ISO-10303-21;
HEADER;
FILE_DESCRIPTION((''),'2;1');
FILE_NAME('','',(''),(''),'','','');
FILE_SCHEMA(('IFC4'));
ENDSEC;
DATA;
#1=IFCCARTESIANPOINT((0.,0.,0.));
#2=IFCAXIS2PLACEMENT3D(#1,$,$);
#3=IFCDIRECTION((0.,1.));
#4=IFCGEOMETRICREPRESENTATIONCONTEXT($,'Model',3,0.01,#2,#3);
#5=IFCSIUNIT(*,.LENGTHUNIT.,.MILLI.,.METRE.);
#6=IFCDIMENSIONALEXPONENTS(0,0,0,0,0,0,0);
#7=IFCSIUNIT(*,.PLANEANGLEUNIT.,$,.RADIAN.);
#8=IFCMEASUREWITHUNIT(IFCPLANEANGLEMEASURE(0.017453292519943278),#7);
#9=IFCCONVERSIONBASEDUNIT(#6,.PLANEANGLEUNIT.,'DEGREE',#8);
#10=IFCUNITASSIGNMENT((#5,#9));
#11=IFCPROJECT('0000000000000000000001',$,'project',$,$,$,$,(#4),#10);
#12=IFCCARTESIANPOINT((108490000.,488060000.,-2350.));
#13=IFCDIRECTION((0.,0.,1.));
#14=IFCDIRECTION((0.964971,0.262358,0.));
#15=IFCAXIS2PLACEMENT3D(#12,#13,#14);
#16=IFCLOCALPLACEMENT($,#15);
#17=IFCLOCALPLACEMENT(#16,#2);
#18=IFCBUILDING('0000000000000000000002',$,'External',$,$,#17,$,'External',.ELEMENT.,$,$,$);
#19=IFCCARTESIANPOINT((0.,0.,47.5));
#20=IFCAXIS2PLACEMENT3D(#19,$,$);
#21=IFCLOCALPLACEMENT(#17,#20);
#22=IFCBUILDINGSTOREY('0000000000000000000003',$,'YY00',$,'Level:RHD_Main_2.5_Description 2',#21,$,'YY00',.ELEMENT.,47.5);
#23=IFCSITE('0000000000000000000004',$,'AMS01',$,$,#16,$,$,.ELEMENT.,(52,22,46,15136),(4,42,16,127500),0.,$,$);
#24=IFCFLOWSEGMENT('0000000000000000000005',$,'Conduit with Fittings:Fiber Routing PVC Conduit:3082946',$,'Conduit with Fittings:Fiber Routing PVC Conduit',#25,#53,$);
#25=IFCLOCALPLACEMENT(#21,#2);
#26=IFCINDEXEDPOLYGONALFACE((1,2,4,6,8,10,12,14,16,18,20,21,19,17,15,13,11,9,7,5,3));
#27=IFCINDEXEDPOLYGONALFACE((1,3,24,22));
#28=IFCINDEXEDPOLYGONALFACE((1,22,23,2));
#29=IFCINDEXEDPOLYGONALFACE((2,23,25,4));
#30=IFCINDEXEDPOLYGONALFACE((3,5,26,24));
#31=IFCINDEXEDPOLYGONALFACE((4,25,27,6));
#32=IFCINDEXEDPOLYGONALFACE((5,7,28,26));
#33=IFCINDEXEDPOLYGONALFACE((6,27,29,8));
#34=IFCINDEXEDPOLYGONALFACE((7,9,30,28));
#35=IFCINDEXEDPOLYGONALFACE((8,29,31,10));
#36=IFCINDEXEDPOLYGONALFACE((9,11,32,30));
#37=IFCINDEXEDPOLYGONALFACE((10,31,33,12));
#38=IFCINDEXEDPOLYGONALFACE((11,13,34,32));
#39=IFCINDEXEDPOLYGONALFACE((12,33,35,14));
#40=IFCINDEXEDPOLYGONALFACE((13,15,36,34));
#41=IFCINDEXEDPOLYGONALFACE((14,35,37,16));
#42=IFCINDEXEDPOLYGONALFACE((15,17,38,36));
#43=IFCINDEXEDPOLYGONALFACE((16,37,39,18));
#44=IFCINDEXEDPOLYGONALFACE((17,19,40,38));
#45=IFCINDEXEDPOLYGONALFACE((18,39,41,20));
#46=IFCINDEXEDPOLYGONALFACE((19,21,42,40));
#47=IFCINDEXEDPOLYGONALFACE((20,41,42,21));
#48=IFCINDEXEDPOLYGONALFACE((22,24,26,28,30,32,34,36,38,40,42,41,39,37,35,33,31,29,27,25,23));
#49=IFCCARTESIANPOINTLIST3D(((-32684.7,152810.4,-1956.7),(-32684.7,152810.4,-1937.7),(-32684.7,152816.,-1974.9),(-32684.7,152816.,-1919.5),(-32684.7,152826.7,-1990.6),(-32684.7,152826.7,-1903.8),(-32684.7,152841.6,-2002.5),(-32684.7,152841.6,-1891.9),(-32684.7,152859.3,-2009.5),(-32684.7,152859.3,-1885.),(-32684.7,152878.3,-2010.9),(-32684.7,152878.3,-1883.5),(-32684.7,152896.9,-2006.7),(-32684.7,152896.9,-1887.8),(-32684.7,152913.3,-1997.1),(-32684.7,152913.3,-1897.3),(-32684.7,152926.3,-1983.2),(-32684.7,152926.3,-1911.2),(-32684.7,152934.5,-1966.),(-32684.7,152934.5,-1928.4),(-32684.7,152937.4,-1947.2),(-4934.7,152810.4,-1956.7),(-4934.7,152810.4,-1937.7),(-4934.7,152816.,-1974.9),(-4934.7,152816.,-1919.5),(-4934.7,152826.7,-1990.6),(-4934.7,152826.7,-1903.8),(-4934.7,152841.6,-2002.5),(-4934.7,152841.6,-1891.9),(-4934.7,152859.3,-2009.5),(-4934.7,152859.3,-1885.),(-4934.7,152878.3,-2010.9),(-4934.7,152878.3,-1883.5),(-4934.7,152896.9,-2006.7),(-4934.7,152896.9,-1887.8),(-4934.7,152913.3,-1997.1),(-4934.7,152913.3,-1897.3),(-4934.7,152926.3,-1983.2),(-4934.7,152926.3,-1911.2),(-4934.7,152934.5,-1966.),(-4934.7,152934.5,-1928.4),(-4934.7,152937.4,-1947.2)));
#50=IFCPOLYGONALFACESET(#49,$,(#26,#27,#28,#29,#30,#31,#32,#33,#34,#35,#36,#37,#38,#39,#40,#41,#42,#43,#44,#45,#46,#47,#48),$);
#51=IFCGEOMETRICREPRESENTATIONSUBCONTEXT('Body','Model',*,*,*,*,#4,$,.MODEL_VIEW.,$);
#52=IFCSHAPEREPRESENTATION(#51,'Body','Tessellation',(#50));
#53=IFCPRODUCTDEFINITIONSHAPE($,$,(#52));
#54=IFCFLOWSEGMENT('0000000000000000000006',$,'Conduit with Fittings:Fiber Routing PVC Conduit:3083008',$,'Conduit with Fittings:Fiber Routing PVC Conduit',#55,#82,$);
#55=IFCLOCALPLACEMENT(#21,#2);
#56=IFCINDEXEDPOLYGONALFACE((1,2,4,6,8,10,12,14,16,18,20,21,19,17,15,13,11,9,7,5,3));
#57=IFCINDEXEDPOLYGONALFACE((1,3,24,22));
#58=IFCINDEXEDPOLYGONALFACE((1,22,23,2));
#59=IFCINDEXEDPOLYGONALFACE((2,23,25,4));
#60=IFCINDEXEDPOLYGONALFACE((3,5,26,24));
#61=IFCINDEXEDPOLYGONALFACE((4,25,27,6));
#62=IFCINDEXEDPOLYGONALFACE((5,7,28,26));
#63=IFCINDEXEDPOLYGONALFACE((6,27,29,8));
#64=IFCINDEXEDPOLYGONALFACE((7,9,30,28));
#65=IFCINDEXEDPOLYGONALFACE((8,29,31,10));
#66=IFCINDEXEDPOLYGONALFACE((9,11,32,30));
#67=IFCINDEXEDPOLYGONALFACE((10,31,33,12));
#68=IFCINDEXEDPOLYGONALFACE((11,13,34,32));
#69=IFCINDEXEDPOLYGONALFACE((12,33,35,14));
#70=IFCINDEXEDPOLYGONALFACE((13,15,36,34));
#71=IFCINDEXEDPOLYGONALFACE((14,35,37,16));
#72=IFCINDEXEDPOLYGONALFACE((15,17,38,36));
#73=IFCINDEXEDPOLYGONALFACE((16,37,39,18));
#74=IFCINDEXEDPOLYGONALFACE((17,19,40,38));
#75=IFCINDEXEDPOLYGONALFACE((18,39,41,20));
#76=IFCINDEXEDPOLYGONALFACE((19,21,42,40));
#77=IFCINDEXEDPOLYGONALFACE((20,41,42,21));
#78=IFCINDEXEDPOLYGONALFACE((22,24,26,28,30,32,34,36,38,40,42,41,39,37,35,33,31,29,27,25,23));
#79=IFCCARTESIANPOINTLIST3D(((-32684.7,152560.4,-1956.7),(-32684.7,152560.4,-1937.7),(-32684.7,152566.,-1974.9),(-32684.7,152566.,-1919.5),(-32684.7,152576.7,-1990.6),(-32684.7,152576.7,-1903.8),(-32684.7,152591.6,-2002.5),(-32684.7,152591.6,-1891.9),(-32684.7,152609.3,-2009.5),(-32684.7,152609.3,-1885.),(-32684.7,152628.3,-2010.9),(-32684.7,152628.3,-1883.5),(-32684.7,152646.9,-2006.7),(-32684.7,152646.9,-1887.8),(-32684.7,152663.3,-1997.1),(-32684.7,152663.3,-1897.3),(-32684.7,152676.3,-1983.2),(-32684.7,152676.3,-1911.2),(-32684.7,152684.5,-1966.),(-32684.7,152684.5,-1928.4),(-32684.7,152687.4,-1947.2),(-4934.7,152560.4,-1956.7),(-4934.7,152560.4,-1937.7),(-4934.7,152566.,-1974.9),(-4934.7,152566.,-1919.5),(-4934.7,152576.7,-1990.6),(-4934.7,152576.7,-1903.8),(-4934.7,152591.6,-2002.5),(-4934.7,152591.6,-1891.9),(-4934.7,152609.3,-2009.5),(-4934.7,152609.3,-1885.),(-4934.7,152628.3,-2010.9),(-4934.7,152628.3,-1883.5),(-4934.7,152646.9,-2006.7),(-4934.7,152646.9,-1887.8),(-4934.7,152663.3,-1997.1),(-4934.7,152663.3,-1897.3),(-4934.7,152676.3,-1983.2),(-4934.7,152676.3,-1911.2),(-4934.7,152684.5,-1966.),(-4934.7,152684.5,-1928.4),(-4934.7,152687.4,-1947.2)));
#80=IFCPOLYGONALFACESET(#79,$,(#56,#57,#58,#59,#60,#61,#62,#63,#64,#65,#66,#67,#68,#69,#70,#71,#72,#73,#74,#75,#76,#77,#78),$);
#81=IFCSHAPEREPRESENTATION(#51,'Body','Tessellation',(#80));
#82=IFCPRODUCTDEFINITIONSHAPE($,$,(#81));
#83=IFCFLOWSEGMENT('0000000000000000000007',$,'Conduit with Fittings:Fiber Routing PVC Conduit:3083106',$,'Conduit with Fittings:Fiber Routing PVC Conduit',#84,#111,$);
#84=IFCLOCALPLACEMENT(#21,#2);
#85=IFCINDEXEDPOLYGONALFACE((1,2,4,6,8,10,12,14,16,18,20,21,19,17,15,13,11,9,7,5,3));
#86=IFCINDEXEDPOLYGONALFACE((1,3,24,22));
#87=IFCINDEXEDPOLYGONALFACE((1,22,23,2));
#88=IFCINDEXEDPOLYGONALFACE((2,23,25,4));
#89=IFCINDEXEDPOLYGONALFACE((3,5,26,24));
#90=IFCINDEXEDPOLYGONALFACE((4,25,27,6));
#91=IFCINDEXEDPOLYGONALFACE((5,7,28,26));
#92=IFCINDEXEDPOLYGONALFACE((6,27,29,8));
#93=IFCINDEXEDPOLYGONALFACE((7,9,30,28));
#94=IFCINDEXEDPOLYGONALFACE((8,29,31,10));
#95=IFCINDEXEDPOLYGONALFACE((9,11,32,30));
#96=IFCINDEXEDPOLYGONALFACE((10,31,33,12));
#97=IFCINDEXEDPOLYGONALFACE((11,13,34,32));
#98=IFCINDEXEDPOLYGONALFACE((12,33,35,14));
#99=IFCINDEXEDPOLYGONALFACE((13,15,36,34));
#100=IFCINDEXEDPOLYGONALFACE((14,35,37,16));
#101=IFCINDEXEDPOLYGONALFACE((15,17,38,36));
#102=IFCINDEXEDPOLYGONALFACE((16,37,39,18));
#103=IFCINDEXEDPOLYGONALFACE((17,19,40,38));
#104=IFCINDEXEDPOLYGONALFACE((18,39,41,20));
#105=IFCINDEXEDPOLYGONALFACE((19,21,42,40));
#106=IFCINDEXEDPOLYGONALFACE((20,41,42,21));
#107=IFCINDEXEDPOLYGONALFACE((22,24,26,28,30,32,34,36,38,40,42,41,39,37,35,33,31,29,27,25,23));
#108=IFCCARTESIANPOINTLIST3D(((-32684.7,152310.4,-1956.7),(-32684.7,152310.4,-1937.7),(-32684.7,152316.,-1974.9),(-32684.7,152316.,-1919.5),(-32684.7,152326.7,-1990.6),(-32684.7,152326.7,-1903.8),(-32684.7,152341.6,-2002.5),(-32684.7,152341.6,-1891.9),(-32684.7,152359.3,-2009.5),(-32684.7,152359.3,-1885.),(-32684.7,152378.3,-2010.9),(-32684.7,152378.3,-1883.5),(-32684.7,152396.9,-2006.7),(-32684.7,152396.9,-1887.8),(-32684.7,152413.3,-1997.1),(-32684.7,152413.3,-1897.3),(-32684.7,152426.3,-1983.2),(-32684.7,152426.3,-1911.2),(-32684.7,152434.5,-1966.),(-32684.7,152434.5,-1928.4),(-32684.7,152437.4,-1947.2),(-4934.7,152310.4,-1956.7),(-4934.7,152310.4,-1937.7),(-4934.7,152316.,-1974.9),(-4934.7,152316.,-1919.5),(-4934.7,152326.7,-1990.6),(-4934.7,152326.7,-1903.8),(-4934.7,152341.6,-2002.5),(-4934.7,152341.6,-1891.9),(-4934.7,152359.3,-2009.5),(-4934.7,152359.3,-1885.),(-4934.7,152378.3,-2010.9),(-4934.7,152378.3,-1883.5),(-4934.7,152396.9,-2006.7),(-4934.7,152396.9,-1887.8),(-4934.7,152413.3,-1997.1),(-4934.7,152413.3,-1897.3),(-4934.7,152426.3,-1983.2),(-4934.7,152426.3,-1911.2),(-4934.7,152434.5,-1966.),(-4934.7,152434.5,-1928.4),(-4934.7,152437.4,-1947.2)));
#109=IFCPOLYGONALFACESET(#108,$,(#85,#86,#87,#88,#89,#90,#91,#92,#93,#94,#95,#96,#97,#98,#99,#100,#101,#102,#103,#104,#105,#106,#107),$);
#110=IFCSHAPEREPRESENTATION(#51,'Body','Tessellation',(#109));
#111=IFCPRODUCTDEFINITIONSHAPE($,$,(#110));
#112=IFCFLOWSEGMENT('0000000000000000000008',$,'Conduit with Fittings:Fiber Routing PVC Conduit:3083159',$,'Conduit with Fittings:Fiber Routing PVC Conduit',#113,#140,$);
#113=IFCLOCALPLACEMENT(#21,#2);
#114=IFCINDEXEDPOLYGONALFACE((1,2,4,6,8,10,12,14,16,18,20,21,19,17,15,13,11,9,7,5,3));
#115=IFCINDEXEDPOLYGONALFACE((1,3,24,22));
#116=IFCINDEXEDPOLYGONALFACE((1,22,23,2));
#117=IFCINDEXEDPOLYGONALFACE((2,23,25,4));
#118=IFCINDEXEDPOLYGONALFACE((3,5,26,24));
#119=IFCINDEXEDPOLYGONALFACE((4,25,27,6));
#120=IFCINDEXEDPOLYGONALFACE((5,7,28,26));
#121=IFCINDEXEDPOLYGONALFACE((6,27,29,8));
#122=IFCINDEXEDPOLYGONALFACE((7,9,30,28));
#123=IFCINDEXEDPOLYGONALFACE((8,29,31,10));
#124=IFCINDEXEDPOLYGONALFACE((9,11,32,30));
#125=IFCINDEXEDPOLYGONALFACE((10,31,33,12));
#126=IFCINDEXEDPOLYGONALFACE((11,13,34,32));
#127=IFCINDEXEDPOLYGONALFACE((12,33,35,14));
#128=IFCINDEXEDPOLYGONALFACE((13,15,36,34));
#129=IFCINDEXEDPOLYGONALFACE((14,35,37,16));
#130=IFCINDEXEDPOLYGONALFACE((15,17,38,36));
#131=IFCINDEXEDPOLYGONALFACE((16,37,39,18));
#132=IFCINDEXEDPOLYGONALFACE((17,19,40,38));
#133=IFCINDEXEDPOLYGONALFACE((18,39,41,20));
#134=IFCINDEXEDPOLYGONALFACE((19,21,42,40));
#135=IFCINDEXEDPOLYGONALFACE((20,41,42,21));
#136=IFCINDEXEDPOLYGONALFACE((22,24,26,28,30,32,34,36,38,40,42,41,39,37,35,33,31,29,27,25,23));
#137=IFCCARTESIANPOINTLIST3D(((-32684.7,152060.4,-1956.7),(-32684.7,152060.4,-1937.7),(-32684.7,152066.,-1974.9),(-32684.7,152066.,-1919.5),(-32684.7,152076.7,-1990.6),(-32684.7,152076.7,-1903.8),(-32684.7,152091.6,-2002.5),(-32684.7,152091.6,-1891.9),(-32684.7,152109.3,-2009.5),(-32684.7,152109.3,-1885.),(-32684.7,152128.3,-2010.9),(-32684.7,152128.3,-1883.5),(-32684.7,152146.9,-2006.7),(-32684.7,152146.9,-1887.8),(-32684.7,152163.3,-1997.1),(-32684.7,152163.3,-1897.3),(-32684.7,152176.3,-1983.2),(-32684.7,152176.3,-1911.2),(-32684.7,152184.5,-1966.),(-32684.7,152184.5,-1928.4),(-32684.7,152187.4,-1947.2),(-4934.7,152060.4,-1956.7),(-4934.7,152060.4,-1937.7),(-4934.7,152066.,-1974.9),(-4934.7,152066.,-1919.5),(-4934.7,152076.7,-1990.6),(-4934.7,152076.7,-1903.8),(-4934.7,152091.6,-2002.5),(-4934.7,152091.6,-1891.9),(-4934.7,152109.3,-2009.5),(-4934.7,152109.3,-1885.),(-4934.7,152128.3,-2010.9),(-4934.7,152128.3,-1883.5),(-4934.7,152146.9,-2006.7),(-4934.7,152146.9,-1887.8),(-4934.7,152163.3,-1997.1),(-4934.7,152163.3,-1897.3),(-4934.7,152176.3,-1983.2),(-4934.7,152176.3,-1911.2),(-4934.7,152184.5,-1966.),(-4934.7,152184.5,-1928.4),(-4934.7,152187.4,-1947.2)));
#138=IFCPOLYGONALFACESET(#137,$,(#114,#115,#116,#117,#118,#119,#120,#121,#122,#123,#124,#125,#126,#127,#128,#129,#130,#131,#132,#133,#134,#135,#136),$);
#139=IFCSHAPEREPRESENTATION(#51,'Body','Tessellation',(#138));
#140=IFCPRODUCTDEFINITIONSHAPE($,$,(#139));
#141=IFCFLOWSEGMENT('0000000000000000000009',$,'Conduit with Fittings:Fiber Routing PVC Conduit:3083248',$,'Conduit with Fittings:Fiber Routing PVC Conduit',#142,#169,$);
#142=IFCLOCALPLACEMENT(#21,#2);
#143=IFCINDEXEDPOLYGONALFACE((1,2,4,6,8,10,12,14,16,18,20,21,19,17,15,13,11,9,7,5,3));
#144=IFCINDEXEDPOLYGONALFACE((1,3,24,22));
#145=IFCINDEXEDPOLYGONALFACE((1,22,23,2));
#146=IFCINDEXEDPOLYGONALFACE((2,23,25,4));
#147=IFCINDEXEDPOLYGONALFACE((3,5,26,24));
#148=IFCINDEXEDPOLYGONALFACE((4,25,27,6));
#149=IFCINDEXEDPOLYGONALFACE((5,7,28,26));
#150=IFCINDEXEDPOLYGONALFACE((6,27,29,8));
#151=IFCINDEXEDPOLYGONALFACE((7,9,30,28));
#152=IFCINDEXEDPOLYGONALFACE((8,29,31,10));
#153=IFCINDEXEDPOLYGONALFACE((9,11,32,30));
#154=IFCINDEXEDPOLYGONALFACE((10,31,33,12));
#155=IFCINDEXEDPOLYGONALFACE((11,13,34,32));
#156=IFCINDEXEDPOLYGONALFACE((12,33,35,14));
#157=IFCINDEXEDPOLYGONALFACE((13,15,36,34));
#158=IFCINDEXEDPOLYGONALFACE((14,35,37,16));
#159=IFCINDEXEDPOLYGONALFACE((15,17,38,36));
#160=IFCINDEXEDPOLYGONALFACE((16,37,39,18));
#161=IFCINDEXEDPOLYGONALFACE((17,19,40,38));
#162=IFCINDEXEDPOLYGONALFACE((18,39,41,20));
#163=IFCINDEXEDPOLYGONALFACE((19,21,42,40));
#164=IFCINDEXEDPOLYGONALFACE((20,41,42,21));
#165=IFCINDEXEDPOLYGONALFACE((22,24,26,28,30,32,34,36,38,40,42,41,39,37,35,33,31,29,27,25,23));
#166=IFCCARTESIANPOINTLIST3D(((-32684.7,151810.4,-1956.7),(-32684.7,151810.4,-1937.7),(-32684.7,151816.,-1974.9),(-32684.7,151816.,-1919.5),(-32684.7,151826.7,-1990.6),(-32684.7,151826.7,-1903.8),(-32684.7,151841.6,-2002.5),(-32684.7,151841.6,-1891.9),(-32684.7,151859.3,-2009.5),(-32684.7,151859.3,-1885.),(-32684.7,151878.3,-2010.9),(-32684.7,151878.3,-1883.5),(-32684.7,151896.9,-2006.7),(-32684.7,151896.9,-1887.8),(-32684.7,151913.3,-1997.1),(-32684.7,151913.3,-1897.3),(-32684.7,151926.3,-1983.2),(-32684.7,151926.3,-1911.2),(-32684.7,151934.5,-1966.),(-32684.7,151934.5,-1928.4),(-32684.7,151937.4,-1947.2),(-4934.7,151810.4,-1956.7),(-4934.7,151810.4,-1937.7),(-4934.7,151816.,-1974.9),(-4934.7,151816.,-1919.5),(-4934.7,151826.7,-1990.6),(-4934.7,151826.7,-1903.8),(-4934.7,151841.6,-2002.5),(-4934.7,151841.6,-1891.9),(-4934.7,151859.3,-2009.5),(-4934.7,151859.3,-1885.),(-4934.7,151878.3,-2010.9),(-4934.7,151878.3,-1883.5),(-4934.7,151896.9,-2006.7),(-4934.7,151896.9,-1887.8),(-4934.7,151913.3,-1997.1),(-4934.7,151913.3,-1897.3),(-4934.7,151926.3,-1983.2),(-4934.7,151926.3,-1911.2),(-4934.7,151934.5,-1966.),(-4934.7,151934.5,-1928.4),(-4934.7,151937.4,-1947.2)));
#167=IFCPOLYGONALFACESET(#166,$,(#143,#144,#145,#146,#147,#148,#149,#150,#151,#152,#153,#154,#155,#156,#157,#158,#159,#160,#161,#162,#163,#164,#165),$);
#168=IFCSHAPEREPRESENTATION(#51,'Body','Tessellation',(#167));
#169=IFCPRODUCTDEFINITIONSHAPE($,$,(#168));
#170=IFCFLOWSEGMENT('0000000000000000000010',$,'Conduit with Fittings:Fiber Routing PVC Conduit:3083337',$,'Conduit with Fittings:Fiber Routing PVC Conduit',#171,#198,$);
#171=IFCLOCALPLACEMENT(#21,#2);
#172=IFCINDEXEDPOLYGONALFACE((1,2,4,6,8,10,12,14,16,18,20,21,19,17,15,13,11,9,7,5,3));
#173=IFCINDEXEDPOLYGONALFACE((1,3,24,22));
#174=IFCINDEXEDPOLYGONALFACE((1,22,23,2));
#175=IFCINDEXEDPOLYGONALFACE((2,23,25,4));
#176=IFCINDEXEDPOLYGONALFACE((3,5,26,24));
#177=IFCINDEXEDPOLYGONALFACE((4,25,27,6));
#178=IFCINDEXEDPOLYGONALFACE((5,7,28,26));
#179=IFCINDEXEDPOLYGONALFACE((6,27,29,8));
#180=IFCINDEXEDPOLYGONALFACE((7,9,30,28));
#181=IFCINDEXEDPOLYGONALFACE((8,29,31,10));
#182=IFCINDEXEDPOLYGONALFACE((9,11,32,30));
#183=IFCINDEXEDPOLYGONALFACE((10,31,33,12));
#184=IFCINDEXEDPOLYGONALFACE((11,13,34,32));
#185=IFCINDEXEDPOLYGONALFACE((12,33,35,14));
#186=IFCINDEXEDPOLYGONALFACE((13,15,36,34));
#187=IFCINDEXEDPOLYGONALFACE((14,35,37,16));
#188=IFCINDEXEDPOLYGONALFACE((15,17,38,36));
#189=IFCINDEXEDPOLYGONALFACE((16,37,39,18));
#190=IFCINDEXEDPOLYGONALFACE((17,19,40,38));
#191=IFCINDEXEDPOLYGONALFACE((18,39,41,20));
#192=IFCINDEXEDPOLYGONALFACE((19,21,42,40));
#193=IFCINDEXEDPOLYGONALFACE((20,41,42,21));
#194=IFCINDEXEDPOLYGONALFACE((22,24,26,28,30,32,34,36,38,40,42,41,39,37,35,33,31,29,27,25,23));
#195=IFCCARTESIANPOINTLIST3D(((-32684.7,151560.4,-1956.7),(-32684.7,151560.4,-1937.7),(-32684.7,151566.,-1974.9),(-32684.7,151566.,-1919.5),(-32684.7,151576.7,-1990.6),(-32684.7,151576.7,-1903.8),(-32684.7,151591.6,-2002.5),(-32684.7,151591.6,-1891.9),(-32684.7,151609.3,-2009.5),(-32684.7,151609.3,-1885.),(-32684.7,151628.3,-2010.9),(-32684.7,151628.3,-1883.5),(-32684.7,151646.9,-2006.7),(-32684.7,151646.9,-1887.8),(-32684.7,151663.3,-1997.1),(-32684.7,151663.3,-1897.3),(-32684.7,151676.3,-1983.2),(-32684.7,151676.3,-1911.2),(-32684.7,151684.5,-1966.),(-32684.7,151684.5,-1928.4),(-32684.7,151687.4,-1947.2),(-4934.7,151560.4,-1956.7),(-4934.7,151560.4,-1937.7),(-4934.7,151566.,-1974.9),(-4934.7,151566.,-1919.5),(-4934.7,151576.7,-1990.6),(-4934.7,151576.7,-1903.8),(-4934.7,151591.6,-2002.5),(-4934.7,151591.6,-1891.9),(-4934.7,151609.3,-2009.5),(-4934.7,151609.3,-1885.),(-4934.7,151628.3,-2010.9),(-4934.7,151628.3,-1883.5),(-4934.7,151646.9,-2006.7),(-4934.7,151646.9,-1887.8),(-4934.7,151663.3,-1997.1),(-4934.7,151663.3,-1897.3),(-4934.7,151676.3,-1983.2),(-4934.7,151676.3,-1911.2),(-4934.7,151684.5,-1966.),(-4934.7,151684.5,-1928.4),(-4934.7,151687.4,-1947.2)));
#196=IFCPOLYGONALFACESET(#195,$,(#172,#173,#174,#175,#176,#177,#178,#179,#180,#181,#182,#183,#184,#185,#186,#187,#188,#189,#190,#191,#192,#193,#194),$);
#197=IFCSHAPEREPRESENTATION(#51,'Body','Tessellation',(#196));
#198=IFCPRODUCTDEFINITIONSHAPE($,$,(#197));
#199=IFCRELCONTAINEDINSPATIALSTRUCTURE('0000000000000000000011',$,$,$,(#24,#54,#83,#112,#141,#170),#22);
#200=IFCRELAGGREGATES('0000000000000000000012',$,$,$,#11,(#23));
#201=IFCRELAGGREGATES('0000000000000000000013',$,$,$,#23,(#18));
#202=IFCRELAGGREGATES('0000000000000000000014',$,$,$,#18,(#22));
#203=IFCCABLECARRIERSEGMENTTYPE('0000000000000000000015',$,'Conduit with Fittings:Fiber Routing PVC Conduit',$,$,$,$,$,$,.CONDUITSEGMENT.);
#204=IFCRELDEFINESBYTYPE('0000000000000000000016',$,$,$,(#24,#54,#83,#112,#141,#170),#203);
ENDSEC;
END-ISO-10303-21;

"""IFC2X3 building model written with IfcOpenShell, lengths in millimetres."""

from ifc_helpers import new_model, entity, si_unit, converted_unit, direction, frame, frame_2d, origin, place, context, subcontext, project, spatial, circle, extrude, type_object, element, save


model = new_model("IFC2X3")

# Units and contexts
model_context = context("Model", 3, precision=0.01, world=origin(), true_north=direction((0.0, 1.0)))
body_context = subcontext(model_context, "Body", "Model", "MODEL_VIEW")
ifc_project = project(units=[si_unit("LENGTHUNIT", "METRE", prefix="MILLI"), converted_unit("PLANEANGLEUNIT", "DEGREE", entity("IfcPlaneAngleMeasure", 0.017453292519943278), si_unit("PLANEANGLEUNIT", "RADIAN"), dimensions=[0, 0, 0, 0, 0, 0, 0])], contexts=[model_context])

# Site, building, storey
site_placement = place(None, frame((108490000.0, 488060000.0, -2350.0), z_axis=(0.0, 0.0, 1.0), x_axis=(0.964971, 0.262358, 0.0)))
site = spatial("IfcSite", under=ifc_project, at=site_placement, Name="AMS01", CompositionType="ELEMENT", RefLatitude=(52, 22, 46, 15136), RefLongitude=(4, 42, 16, 127500), RefElevation=0.0)
building_placement = place(site_placement, origin())
building = spatial("IfcBuilding", under=site, at=building_placement, Name="External", LongName="External", CompositionType="ELEMENT")
storey_placement = place(building_placement, frame((0.0, 0.0, 47.5)))
storey = spatial("IfcBuildingStorey", under=building, at=storey_placement, Name="YY00", ObjectType="Level:RHD_Main_2.5_Description 2", LongName="YY00", CompositionType="ELEMENT", Elevation=47.5)

# Flow segments
cable_carrier_segment_type = type_object("IfcCableCarrierSegmentType", Name="Conduit with Fittings:Fiber Routing PVC Conduit", PredefinedType="CONDUITSEGMENT")
flow_segment_1_placement = place(storey_placement, origin())
element("IfcFlowSegment", 1, at=flow_segment_1_placement, inside=storey, type_object=cable_carrier_segment_type, Name="Conduit with Fittings:Fiber Routing PVC Conduit:3082946", ObjectType="Conduit with Fittings:Fiber Routing PVC Conduit", context=body_context, shape_type="SweptSolid", body=[
    extrude(circle(Radius=63.9, at=frame_2d((0.0, 0.0), x_axis=(1.0, 0.0))), frame((-32684.7, 152873.5, -1947.2), z_axis=(1.0, 0.0, 0.0), x_axis=(0.0, 1.0, 0.0)), (0.0, 0.0, 1.0), 27750.0),
])
flow_segment_2_placement = place(storey_placement, origin())
element("IfcFlowSegment", 2, at=flow_segment_2_placement, inside=storey, type_object=cable_carrier_segment_type, Name="Conduit with Fittings:Fiber Routing PVC Conduit:3083008", ObjectType="Conduit with Fittings:Fiber Routing PVC Conduit", context=body_context, shape_type="SweptSolid", body=[
    extrude(circle(Radius=63.9, at=frame_2d((0.0, 0.0), x_axis=(1.0, 0.0))), frame((-32684.7, 152623.5, -1947.2), z_axis=(1.0, 0.0, 0.0), x_axis=(0.0, 1.0, 0.0)), (0.0, 0.0, 1.0), 27750.0),
])
flow_segment_3_placement = place(storey_placement, origin())
element("IfcFlowSegment", 3, at=flow_segment_3_placement, inside=storey, type_object=cable_carrier_segment_type, Name="Conduit with Fittings:Fiber Routing PVC Conduit:3083106", ObjectType="Conduit with Fittings:Fiber Routing PVC Conduit", context=body_context, shape_type="SweptSolid", body=[
    extrude(circle(Radius=63.9, at=frame_2d((0.0, 0.0), x_axis=(1.0, 0.0))), frame((-32684.7, 152373.5, -1947.2), z_axis=(1.0, 0.0, 0.0), x_axis=(0.0, 1.0, 0.0)), (0.0, 0.0, 1.0), 27750.0),
])
flow_segment_4_placement = place(storey_placement, origin())
element("IfcFlowSegment", 4, at=flow_segment_4_placement, inside=storey, type_object=cable_carrier_segment_type, Name="Conduit with Fittings:Fiber Routing PVC Conduit:3083159", ObjectType="Conduit with Fittings:Fiber Routing PVC Conduit", context=body_context, shape_type="SweptSolid", body=[
    extrude(circle(Radius=63.9, at=frame_2d((0.0, 0.0), x_axis=(1.0, 0.0))), frame((-32684.7, 152123.5, -1947.2), z_axis=(1.0, 0.0, 0.0), x_axis=(0.0, 1.0, 0.0)), (0.0, 0.0, 1.0), 27750.0),
])
flow_segment_5_placement = place(storey_placement, origin())
element("IfcFlowSegment", 5, at=flow_segment_5_placement, inside=storey, type_object=cable_carrier_segment_type, Name="Conduit with Fittings:Fiber Routing PVC Conduit:3083248", ObjectType="Conduit with Fittings:Fiber Routing PVC Conduit", context=body_context, shape_type="SweptSolid", body=[
    extrude(circle(Radius=63.9, at=frame_2d((0.0, 0.0), x_axis=(1.0, 0.0))), frame((-32684.7, 151873.5, -1947.2), z_axis=(1.0, 0.0, 0.0), x_axis=(0.0, 1.0, 0.0)), (0.0, 0.0, 1.0), 27750.0),
])
flow_segment_6_placement = place(storey_placement, origin())
element("IfcFlowSegment", 6, at=flow_segment_6_placement, inside=storey, type_object=cable_carrier_segment_type, Name="Conduit with Fittings:Fiber Routing PVC Conduit:3083337", ObjectType="Conduit with Fittings:Fiber Routing PVC Conduit", context=body_context, shape_type="SweptSolid", body=[
    extrude(circle(Radius=63.9, at=frame_2d((0.0, 0.0), x_axis=(1.0, 0.0))), frame((-32684.7, 151623.5, -1947.2), z_axis=(1.0, 0.0, 0.0), x_axis=(0.0, 1.0, 0.0)), (0.0, 0.0, 1.0), 27750.0),
])

save(model, "model.ifc")
